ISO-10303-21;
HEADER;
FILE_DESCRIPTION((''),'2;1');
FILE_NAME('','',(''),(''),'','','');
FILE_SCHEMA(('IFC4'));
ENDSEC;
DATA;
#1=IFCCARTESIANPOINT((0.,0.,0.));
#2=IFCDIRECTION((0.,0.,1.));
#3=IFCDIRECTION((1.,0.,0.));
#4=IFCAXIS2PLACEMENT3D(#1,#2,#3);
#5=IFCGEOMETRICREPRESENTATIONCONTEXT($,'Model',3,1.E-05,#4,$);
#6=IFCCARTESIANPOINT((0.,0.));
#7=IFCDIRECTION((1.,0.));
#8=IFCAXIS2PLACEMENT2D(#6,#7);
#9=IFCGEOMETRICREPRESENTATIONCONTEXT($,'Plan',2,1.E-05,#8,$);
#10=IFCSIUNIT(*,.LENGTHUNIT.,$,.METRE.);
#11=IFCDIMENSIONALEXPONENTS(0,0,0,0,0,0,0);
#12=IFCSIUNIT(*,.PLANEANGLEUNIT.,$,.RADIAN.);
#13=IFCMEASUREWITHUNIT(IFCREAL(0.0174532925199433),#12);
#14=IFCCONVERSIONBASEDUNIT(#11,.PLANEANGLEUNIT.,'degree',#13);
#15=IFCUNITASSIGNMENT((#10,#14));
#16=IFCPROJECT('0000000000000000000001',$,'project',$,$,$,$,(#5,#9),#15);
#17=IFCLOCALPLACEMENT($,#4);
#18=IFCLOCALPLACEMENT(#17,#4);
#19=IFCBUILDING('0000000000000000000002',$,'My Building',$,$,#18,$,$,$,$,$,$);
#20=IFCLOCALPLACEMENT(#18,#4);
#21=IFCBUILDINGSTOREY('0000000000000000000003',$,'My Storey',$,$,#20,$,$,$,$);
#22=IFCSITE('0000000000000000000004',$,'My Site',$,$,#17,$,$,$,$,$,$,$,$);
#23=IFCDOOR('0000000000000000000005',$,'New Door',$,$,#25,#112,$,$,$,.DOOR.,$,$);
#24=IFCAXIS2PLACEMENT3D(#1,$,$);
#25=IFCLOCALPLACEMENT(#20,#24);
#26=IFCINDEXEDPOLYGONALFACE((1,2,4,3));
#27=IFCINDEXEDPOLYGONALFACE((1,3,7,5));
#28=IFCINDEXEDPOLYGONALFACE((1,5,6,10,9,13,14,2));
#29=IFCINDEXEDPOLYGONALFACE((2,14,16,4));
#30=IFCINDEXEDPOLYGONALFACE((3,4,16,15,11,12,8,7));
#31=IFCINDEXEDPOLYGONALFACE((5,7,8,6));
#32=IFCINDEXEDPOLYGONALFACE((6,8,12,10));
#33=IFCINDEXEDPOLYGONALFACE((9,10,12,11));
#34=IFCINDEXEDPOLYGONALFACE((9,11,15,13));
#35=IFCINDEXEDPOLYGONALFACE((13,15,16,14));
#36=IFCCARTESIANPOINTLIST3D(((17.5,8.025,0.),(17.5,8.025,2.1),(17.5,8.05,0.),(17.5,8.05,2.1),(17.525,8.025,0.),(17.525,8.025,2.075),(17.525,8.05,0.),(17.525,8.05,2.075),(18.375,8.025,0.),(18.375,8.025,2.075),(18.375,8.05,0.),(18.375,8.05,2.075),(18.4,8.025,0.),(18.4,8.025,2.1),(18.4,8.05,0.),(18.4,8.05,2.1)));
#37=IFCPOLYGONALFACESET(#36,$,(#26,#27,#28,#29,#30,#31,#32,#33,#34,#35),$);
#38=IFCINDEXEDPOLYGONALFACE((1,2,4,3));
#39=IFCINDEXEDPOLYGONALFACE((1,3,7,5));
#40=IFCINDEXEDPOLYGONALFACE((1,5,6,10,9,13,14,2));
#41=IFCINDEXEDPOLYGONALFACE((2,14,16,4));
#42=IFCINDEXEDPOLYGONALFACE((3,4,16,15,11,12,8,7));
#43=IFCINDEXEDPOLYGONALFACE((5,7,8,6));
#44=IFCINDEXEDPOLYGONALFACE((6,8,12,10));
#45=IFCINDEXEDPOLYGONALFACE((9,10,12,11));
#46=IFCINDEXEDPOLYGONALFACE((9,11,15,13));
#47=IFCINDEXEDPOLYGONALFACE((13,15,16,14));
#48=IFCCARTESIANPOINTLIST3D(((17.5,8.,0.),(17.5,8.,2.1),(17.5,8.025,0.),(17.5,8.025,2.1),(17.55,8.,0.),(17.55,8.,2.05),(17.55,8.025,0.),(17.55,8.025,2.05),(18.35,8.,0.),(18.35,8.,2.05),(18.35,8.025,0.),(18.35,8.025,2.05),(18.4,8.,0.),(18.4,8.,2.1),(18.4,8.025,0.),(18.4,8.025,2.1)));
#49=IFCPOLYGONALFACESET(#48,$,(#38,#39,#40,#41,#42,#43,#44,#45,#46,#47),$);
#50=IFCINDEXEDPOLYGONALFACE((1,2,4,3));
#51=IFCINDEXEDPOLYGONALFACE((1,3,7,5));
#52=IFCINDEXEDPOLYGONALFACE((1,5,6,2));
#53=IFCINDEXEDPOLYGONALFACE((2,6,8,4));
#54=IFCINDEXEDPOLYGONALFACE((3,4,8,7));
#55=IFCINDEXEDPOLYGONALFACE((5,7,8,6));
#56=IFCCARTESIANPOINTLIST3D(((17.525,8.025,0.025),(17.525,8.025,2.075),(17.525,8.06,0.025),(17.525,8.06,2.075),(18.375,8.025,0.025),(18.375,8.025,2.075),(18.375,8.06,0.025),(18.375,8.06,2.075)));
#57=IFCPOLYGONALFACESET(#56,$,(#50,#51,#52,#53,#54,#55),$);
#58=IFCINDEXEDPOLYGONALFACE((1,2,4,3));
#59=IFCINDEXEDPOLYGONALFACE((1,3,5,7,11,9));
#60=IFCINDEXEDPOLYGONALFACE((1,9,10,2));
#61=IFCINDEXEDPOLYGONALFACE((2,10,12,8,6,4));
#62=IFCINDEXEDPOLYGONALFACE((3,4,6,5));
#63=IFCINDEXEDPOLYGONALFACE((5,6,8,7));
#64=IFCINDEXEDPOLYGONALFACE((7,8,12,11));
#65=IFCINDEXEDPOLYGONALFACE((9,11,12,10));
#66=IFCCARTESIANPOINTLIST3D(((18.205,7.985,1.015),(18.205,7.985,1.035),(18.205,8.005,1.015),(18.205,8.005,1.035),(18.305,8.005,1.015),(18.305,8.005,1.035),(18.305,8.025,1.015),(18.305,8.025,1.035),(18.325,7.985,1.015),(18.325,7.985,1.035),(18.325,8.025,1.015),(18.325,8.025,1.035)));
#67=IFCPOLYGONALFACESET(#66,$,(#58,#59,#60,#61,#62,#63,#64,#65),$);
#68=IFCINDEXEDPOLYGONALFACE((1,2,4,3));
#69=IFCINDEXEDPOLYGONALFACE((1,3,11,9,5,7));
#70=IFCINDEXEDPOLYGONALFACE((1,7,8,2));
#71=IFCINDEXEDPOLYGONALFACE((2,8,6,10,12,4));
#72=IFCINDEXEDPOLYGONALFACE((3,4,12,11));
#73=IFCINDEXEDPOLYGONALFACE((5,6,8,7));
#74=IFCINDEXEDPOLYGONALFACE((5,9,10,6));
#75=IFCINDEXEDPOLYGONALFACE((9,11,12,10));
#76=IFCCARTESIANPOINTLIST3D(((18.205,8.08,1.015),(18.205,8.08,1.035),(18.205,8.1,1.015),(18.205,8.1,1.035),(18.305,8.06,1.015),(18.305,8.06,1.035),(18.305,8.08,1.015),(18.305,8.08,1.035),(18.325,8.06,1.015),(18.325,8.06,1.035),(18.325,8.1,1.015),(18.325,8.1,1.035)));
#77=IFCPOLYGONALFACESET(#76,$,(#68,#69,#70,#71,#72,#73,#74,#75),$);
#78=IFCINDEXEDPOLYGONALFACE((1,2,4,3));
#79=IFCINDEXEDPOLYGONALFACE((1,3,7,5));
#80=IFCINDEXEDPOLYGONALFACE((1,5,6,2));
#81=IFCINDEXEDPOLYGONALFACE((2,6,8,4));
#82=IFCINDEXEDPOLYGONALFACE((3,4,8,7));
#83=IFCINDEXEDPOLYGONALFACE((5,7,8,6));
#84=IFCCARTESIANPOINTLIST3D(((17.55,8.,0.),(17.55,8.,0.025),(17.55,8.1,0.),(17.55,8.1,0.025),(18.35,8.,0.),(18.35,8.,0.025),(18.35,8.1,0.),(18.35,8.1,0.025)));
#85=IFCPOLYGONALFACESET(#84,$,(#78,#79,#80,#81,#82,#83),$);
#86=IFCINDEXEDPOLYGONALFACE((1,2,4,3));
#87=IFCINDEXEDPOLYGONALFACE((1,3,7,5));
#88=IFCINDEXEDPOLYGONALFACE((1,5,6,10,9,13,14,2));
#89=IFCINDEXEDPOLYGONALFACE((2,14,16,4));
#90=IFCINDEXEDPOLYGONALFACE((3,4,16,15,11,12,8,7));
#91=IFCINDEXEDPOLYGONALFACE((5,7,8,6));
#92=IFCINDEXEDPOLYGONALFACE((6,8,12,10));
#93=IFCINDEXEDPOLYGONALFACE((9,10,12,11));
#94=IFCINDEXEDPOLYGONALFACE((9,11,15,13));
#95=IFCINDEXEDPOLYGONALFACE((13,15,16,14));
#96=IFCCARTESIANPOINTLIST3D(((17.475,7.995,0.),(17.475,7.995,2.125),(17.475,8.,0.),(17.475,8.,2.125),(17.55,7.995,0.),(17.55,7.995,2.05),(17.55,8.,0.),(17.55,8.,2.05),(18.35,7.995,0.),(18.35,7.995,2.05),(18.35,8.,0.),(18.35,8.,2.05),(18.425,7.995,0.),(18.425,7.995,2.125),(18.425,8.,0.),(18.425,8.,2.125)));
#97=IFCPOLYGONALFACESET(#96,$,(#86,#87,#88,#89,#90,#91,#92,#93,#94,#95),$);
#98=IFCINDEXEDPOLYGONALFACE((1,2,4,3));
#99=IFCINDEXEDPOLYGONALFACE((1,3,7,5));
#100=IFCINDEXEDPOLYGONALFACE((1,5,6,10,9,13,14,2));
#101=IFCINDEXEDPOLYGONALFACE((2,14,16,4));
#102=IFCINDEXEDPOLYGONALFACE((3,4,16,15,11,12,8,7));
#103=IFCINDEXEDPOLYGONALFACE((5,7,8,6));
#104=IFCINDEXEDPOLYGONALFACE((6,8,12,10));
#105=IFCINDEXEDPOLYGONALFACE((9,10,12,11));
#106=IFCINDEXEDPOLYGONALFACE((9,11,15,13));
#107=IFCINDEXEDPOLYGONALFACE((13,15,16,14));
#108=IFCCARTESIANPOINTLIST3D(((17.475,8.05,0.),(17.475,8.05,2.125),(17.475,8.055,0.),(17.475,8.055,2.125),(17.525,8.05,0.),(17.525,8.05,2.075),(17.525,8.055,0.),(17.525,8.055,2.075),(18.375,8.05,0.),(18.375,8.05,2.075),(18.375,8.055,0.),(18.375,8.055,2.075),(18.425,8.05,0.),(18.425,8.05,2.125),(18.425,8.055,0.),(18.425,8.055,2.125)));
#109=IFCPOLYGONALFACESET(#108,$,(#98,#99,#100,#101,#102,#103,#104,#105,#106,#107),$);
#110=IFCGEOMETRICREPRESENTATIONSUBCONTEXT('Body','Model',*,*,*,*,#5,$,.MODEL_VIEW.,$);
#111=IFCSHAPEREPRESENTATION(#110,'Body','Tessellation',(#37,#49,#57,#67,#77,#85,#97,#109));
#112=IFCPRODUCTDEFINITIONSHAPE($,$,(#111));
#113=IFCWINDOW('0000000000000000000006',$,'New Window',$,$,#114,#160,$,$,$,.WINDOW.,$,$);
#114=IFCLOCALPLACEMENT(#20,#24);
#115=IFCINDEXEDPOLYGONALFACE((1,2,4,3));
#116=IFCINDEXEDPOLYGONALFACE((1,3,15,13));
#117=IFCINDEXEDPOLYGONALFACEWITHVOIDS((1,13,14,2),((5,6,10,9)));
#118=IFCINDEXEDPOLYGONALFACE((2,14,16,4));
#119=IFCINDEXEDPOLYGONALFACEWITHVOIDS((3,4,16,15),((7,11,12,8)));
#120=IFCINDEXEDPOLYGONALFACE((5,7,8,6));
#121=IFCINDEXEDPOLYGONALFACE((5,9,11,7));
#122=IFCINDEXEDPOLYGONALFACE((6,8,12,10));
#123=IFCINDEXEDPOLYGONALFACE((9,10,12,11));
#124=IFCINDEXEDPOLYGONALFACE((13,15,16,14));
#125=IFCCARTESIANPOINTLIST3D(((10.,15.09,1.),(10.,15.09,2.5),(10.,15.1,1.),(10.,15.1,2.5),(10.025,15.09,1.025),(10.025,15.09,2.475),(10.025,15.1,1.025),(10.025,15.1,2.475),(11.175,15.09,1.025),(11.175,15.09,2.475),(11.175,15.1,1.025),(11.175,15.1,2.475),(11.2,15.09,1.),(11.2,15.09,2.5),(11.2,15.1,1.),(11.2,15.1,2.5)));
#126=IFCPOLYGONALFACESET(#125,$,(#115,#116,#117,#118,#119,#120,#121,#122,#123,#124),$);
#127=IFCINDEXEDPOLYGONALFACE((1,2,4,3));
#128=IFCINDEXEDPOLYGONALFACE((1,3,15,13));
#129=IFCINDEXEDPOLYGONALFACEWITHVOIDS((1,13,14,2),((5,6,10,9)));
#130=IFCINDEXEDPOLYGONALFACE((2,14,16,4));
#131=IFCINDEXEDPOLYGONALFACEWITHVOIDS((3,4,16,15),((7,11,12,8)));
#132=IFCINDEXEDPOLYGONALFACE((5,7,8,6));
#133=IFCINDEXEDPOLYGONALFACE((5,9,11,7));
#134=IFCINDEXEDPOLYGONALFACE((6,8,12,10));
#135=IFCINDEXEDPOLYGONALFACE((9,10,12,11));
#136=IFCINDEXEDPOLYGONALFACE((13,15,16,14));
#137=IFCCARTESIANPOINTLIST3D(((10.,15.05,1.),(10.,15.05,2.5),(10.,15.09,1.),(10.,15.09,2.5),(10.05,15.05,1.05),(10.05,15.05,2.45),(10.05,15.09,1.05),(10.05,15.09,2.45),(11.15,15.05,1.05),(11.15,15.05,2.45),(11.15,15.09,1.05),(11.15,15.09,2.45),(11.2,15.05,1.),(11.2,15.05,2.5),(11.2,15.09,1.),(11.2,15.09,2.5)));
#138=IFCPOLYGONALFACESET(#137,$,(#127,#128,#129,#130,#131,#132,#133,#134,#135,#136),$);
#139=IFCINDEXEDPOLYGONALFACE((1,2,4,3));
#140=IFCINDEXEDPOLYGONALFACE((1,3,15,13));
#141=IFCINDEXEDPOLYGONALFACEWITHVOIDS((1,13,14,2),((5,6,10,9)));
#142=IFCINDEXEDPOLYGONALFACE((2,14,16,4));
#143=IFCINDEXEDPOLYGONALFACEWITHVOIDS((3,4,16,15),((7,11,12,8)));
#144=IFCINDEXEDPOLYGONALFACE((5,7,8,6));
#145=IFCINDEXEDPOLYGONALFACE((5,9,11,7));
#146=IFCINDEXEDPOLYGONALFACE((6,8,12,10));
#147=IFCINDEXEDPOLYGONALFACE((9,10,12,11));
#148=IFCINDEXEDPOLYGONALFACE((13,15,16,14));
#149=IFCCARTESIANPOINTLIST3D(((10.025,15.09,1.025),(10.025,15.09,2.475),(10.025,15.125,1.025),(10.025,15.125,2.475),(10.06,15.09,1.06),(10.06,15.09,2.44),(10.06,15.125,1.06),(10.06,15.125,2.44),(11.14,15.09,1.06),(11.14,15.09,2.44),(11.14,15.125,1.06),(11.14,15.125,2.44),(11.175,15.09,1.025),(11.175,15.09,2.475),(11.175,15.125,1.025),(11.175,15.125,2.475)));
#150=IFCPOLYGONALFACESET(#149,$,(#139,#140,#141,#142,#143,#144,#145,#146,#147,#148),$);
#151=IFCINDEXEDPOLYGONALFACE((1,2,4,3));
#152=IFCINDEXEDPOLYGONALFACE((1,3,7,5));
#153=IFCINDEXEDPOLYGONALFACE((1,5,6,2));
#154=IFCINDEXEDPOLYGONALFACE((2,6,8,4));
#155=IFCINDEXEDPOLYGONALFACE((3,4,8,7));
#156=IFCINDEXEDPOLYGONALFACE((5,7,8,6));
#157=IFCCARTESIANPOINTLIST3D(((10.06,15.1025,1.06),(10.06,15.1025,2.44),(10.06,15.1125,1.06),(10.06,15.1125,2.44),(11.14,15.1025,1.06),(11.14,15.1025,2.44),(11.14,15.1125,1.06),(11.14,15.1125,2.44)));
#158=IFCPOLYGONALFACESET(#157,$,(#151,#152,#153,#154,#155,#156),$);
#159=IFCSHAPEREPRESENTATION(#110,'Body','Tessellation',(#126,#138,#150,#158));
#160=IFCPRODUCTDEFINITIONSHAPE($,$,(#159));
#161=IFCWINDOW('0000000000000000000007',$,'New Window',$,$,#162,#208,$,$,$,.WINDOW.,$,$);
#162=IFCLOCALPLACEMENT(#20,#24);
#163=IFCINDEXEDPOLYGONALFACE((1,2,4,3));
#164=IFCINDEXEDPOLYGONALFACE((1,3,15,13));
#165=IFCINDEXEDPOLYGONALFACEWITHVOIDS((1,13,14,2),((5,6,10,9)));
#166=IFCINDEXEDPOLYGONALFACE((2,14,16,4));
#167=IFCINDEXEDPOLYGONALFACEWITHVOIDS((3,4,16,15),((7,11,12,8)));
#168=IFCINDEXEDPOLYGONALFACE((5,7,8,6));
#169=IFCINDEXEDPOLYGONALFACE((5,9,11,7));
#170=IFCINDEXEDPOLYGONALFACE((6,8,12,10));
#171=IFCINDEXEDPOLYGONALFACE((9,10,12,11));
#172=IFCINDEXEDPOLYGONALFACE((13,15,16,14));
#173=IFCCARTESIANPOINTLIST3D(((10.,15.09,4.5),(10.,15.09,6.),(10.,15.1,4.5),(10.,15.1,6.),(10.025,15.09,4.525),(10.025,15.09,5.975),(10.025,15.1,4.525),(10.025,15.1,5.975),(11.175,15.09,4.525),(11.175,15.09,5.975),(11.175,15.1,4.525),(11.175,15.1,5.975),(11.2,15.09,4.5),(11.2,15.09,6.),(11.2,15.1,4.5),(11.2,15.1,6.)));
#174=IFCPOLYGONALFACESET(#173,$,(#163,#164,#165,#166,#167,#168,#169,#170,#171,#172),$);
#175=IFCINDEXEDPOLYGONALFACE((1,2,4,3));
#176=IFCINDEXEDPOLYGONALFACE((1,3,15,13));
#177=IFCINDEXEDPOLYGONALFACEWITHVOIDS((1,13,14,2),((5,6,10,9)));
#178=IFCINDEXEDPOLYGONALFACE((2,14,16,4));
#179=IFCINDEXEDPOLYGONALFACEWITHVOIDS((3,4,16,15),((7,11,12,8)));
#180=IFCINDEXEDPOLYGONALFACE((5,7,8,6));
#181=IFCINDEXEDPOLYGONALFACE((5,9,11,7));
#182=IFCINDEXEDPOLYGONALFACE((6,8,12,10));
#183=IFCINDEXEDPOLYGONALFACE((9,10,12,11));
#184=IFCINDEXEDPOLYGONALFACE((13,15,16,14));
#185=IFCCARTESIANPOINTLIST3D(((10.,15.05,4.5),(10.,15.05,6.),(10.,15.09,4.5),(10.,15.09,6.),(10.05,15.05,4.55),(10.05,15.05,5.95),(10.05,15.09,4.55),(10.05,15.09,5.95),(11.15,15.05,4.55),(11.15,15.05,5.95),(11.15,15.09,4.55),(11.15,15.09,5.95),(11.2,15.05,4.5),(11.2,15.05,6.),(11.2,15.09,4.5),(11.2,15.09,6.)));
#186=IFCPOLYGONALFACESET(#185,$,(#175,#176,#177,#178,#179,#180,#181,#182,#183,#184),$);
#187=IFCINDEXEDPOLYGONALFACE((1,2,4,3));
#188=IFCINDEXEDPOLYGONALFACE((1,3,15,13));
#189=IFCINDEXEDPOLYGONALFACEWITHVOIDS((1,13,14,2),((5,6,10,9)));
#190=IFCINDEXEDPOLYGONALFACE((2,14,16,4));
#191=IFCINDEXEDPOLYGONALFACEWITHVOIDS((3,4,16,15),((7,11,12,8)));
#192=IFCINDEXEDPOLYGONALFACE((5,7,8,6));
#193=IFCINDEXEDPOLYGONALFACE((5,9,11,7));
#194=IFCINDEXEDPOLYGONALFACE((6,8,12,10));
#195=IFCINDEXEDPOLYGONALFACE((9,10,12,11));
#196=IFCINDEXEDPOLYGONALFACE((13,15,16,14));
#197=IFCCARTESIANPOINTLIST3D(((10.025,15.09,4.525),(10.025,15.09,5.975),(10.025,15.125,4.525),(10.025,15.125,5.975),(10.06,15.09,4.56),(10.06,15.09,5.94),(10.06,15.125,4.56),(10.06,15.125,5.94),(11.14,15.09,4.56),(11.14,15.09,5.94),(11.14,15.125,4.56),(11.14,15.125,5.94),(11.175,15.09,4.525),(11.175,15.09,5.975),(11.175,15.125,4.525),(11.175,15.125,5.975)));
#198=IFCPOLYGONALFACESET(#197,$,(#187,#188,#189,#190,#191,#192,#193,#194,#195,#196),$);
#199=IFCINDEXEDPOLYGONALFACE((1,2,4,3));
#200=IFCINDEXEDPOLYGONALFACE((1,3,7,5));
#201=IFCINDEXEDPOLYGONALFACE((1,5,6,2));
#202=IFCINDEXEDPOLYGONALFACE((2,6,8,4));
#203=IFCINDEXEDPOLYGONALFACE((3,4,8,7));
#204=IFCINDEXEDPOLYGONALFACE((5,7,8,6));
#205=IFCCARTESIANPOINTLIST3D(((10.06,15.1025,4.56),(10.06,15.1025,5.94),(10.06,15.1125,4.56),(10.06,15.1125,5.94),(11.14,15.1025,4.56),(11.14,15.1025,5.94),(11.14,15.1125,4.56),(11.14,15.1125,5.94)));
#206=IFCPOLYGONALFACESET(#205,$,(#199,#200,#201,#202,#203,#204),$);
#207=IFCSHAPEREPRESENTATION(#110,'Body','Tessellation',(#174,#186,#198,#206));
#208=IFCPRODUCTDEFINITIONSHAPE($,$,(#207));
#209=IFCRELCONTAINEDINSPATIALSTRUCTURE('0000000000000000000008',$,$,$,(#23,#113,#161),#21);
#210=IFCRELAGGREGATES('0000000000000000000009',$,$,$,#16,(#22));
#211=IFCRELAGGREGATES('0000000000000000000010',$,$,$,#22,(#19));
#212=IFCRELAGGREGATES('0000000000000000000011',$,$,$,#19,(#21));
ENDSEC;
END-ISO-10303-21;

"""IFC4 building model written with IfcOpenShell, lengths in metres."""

from ifc_helpers import new_model, entity, si_unit, converted_unit, frame, origin_with_axes, origin_2d_with_axis, place, context, subcontext, project, spatial, line, indexed_curve, outline, extrude, element, save


model = new_model("IFC4")

# Units and contexts
model_context = context("Model", 3, precision=1e-05, world=origin_with_axes())
plan_context = context("Plan", 2, precision=1e-05, world=origin_2d_with_axis())
body_context = subcontext(model_context, "Body", "Model", "MODEL_VIEW")
ifc_project = project(units=[si_unit("LENGTHUNIT", "METRE"), converted_unit("PLANEANGLEUNIT", "degree", entity("IfcReal", 0.0174532925199433), si_unit("PLANEANGLEUNIT", "RADIAN"), dimensions=[0, 0, 0, 0, 0, 0, 0])], contexts=[model_context, plan_context])

# Site, building, storey
site_placement = place(None, origin_with_axes())
site = spatial("IfcSite", under=ifc_project, at=site_placement, Name="My Site")
building_placement = place(site_placement, origin_with_axes())
building = spatial("IfcBuilding", under=site, at=building_placement, Name="My Building")
storey_placement = place(building_placement, origin_with_axes())
storey = spatial("IfcBuildingStorey", under=building, at=storey_placement, Name="My Storey")

# Door
door_placement = place(storey_placement, frame((17.5, 8.0, 0.0), z_axis=(0.0, 0.0, 1.0), x_axis=(1.0, 0.0, 0.0)))
element("IfcDoor", 1, at=door_placement, inside=storey, Name="New Door", PredefinedType="DOOR", context=body_context, shape_type="SweptSolid", body=[
    extrude(outline(indexed_curve([(0.0, 0.0), (0.0, 2.1), (0.9, 2.1), (0.9, 0.0), (0.875, 0.0), (0.875, 2.075), (0.025, 2.075), (0.025, 0.0)], segments=[line(1, 2, 3, 4, 5, 6, 7, 8, 1)])), frame((0.0, 0.025, 0.0), z_axis=(0.0, -1.0, 0.0), x_axis=(1.0, 0.0, 0.0)), (0.0, 0.0, -1.0), 0.025),
    extrude(outline(indexed_curve([(0.0, 0.0), (0.0, 2.1), (0.9, 2.1), (0.9, 0.0), (0.85, 0.0), (0.85, 2.05), (0.05, 2.05), (0.05, 0.0)], segments=[line(1, 2, 3, 4, 5, 6, 7, 8, 1)])), frame((0.0, 0.0, 0.0), z_axis=(0.0, -1.0, 0.0), x_axis=(1.0, 0.0, 0.0)), (0.0, 0.0, -1.0), 0.025),
    extrude(outline(indexed_curve([(0.0, 0.0), (0.85, 0.0), (0.85, 0.035), (0.0, 0.035)], segments=[line(1, 2, 3, 4, 1)])), frame((0.025, 0.025, 0.025), z_axis=(0.0, 0.0, 1.0), x_axis=(1.0, 0.0, 0.0)), (0.0, 0.0, 1.0), 2.05),
    extrude(outline(indexed_curve([(0.0, 0.0), (0.0, -0.04), (-0.12, -0.04), (-0.12, -0.02), (-0.02, -0.02), (-0.02, 0.0)], segments=[line(1, 2, 3, 4, 5, 6, 1)])), frame((0.825, 0.025, 1.015), z_axis=(0.0, 0.0, 1.0), x_axis=(1.0, 0.0, 0.0)), (0.0, 0.0, 1.0), 0.02),
    extrude(outline(indexed_curve([(0.0, 0.0), (0.0, 0.04), (-0.12, 0.04), (-0.12, 0.02), (-0.02, 0.02), (-0.02, 0.0)], segments=[line(1, 2, 3, 4, 5, 6, 1)])), frame((0.825, 0.06, 1.015), z_axis=(0.0, 0.0, 1.0), x_axis=(1.0, 0.0, 0.0)), (0.0, 0.0, 1.0), 0.02),
    extrude(outline(indexed_curve([(0.0, 0.0), (0.8, 0.0), (0.8, 0.1), (0.0, 0.1)], segments=[line(1, 2, 3, 4, 1)])), frame((0.05, 0.0, 0.0), z_axis=(0.0, 0.0, 1.0), x_axis=(1.0, 0.0, 0.0)), (0.0, 0.0, 1.0), 0.025),
    extrude(outline(indexed_curve([(0.0, 0.0), (0.0, 2.125), (0.95, 2.125), (0.95, 0.0), (0.875, 0.0), (0.875, 2.05), (0.075, 2.05), (0.075, 0.0)], segments=[line(1, 2, 3, 4, 5, 6, 7, 8, 1)])), frame((-0.025, -0.005, 0.0), z_axis=(0.0, -1.0, 0.0), x_axis=(1.0, 0.0, 0.0)), (0.0, 0.0, -1.0), 0.005),
    extrude(outline(indexed_curve([(0.0, 0.0), (0.0, 2.125), (0.95, 2.125), (0.95, 0.0), (0.9, 0.0), (0.9, 2.075), (0.05, 2.075), (0.05, 0.0)], segments=[line(1, 2, 3, 4, 5, 6, 7, 8, 1)])), frame((-0.025, 0.05, 0.0), z_axis=(0.0, -1.0, 0.0), x_axis=(1.0, 0.0, 0.0)), (0.0, 0.0, -1.0), 0.005),
])

# Windows
for number, where, z_axis, x_axis, name in (
    (2, (10.0, 15.0, 1.0), (0.0, 0.0, 1.0), (1.0, 0.0, 0.0), "New Window"),
    (3, (10.0, 15.0, 4.5), (0.0, 0.0, 1.0), (1.0, 0.0, 0.0), "New Window"),
):
    element("IfcWindow", number, at=place(storey_placement, frame(where, z_axis=z_axis, x_axis=x_axis)), inside=storey, Name=name, PredefinedType="WINDOW", context=body_context, shape_type="SweptSolid", body=[
        extrude(outline(indexed_curve([(0.0, 0.0), (1.2, 0.0), (1.2, 1.5), (0.0, 1.5)], segments=[line(1, 2, 3, 4, 1)]), holes=[indexed_curve([(0.025, 0.025), (1.175, 0.025), (1.175, 1.475), (0.025, 1.475)], segments=[line(1, 2, 3, 4, 1)])]), frame((0.0, 0.09, 0.0), z_axis=(0.0, -1.0, 0.0), x_axis=(1.0, 0.0, 0.0)), (0.0, 0.0, -1.0), 0.01),
        extrude(outline(indexed_curve([(0.0, 0.0), (1.2, 0.0), (1.2, 1.5), (0.0, 1.5)], segments=[line(1, 2, 3, 4, 1)]), holes=[indexed_curve([(0.05, 0.05), (1.15, 0.05), (1.15, 1.45), (0.05, 1.45)], segments=[line(1, 2, 3, 4, 1)])]), frame((0.0, 0.05, 0.0), z_axis=(0.0, -1.0, 0.0), x_axis=(1.0, 0.0, 0.0)), (0.0, 0.0, -1.0), 0.04),
        extrude(outline(indexed_curve([(0.0, 0.0), (1.15, 0.0), (1.15, 1.45), (0.0, 1.45)], segments=[line(1, 2, 3, 4, 1)]), holes=[indexed_curve([(0.035, 0.035), (1.115, 0.035), (1.115, 1.415), (0.035, 1.415)], segments=[line(1, 2, 3, 4, 1)])]), frame((0.025, 0.09, 0.025), z_axis=(0.0, -1.0, 0.0), x_axis=(1.0, 0.0, 0.0)), (0.0, 0.0, -1.0), 0.035),
        extrude(outline(indexed_curve([(0.035, 0.035), (1.115, 0.035), (1.115, 1.415), (0.035, 1.415)], segments=[line(1, 2, 3, 4, 1)])), frame((0.025, 0.1025, 0.025), z_axis=(0.0, -1.0, 0.0), x_axis=(1.0, 0.0, 0.0)), (0.0, 0.0, -1.0), 0.01),
    ])

save(model, "model.ifc")
